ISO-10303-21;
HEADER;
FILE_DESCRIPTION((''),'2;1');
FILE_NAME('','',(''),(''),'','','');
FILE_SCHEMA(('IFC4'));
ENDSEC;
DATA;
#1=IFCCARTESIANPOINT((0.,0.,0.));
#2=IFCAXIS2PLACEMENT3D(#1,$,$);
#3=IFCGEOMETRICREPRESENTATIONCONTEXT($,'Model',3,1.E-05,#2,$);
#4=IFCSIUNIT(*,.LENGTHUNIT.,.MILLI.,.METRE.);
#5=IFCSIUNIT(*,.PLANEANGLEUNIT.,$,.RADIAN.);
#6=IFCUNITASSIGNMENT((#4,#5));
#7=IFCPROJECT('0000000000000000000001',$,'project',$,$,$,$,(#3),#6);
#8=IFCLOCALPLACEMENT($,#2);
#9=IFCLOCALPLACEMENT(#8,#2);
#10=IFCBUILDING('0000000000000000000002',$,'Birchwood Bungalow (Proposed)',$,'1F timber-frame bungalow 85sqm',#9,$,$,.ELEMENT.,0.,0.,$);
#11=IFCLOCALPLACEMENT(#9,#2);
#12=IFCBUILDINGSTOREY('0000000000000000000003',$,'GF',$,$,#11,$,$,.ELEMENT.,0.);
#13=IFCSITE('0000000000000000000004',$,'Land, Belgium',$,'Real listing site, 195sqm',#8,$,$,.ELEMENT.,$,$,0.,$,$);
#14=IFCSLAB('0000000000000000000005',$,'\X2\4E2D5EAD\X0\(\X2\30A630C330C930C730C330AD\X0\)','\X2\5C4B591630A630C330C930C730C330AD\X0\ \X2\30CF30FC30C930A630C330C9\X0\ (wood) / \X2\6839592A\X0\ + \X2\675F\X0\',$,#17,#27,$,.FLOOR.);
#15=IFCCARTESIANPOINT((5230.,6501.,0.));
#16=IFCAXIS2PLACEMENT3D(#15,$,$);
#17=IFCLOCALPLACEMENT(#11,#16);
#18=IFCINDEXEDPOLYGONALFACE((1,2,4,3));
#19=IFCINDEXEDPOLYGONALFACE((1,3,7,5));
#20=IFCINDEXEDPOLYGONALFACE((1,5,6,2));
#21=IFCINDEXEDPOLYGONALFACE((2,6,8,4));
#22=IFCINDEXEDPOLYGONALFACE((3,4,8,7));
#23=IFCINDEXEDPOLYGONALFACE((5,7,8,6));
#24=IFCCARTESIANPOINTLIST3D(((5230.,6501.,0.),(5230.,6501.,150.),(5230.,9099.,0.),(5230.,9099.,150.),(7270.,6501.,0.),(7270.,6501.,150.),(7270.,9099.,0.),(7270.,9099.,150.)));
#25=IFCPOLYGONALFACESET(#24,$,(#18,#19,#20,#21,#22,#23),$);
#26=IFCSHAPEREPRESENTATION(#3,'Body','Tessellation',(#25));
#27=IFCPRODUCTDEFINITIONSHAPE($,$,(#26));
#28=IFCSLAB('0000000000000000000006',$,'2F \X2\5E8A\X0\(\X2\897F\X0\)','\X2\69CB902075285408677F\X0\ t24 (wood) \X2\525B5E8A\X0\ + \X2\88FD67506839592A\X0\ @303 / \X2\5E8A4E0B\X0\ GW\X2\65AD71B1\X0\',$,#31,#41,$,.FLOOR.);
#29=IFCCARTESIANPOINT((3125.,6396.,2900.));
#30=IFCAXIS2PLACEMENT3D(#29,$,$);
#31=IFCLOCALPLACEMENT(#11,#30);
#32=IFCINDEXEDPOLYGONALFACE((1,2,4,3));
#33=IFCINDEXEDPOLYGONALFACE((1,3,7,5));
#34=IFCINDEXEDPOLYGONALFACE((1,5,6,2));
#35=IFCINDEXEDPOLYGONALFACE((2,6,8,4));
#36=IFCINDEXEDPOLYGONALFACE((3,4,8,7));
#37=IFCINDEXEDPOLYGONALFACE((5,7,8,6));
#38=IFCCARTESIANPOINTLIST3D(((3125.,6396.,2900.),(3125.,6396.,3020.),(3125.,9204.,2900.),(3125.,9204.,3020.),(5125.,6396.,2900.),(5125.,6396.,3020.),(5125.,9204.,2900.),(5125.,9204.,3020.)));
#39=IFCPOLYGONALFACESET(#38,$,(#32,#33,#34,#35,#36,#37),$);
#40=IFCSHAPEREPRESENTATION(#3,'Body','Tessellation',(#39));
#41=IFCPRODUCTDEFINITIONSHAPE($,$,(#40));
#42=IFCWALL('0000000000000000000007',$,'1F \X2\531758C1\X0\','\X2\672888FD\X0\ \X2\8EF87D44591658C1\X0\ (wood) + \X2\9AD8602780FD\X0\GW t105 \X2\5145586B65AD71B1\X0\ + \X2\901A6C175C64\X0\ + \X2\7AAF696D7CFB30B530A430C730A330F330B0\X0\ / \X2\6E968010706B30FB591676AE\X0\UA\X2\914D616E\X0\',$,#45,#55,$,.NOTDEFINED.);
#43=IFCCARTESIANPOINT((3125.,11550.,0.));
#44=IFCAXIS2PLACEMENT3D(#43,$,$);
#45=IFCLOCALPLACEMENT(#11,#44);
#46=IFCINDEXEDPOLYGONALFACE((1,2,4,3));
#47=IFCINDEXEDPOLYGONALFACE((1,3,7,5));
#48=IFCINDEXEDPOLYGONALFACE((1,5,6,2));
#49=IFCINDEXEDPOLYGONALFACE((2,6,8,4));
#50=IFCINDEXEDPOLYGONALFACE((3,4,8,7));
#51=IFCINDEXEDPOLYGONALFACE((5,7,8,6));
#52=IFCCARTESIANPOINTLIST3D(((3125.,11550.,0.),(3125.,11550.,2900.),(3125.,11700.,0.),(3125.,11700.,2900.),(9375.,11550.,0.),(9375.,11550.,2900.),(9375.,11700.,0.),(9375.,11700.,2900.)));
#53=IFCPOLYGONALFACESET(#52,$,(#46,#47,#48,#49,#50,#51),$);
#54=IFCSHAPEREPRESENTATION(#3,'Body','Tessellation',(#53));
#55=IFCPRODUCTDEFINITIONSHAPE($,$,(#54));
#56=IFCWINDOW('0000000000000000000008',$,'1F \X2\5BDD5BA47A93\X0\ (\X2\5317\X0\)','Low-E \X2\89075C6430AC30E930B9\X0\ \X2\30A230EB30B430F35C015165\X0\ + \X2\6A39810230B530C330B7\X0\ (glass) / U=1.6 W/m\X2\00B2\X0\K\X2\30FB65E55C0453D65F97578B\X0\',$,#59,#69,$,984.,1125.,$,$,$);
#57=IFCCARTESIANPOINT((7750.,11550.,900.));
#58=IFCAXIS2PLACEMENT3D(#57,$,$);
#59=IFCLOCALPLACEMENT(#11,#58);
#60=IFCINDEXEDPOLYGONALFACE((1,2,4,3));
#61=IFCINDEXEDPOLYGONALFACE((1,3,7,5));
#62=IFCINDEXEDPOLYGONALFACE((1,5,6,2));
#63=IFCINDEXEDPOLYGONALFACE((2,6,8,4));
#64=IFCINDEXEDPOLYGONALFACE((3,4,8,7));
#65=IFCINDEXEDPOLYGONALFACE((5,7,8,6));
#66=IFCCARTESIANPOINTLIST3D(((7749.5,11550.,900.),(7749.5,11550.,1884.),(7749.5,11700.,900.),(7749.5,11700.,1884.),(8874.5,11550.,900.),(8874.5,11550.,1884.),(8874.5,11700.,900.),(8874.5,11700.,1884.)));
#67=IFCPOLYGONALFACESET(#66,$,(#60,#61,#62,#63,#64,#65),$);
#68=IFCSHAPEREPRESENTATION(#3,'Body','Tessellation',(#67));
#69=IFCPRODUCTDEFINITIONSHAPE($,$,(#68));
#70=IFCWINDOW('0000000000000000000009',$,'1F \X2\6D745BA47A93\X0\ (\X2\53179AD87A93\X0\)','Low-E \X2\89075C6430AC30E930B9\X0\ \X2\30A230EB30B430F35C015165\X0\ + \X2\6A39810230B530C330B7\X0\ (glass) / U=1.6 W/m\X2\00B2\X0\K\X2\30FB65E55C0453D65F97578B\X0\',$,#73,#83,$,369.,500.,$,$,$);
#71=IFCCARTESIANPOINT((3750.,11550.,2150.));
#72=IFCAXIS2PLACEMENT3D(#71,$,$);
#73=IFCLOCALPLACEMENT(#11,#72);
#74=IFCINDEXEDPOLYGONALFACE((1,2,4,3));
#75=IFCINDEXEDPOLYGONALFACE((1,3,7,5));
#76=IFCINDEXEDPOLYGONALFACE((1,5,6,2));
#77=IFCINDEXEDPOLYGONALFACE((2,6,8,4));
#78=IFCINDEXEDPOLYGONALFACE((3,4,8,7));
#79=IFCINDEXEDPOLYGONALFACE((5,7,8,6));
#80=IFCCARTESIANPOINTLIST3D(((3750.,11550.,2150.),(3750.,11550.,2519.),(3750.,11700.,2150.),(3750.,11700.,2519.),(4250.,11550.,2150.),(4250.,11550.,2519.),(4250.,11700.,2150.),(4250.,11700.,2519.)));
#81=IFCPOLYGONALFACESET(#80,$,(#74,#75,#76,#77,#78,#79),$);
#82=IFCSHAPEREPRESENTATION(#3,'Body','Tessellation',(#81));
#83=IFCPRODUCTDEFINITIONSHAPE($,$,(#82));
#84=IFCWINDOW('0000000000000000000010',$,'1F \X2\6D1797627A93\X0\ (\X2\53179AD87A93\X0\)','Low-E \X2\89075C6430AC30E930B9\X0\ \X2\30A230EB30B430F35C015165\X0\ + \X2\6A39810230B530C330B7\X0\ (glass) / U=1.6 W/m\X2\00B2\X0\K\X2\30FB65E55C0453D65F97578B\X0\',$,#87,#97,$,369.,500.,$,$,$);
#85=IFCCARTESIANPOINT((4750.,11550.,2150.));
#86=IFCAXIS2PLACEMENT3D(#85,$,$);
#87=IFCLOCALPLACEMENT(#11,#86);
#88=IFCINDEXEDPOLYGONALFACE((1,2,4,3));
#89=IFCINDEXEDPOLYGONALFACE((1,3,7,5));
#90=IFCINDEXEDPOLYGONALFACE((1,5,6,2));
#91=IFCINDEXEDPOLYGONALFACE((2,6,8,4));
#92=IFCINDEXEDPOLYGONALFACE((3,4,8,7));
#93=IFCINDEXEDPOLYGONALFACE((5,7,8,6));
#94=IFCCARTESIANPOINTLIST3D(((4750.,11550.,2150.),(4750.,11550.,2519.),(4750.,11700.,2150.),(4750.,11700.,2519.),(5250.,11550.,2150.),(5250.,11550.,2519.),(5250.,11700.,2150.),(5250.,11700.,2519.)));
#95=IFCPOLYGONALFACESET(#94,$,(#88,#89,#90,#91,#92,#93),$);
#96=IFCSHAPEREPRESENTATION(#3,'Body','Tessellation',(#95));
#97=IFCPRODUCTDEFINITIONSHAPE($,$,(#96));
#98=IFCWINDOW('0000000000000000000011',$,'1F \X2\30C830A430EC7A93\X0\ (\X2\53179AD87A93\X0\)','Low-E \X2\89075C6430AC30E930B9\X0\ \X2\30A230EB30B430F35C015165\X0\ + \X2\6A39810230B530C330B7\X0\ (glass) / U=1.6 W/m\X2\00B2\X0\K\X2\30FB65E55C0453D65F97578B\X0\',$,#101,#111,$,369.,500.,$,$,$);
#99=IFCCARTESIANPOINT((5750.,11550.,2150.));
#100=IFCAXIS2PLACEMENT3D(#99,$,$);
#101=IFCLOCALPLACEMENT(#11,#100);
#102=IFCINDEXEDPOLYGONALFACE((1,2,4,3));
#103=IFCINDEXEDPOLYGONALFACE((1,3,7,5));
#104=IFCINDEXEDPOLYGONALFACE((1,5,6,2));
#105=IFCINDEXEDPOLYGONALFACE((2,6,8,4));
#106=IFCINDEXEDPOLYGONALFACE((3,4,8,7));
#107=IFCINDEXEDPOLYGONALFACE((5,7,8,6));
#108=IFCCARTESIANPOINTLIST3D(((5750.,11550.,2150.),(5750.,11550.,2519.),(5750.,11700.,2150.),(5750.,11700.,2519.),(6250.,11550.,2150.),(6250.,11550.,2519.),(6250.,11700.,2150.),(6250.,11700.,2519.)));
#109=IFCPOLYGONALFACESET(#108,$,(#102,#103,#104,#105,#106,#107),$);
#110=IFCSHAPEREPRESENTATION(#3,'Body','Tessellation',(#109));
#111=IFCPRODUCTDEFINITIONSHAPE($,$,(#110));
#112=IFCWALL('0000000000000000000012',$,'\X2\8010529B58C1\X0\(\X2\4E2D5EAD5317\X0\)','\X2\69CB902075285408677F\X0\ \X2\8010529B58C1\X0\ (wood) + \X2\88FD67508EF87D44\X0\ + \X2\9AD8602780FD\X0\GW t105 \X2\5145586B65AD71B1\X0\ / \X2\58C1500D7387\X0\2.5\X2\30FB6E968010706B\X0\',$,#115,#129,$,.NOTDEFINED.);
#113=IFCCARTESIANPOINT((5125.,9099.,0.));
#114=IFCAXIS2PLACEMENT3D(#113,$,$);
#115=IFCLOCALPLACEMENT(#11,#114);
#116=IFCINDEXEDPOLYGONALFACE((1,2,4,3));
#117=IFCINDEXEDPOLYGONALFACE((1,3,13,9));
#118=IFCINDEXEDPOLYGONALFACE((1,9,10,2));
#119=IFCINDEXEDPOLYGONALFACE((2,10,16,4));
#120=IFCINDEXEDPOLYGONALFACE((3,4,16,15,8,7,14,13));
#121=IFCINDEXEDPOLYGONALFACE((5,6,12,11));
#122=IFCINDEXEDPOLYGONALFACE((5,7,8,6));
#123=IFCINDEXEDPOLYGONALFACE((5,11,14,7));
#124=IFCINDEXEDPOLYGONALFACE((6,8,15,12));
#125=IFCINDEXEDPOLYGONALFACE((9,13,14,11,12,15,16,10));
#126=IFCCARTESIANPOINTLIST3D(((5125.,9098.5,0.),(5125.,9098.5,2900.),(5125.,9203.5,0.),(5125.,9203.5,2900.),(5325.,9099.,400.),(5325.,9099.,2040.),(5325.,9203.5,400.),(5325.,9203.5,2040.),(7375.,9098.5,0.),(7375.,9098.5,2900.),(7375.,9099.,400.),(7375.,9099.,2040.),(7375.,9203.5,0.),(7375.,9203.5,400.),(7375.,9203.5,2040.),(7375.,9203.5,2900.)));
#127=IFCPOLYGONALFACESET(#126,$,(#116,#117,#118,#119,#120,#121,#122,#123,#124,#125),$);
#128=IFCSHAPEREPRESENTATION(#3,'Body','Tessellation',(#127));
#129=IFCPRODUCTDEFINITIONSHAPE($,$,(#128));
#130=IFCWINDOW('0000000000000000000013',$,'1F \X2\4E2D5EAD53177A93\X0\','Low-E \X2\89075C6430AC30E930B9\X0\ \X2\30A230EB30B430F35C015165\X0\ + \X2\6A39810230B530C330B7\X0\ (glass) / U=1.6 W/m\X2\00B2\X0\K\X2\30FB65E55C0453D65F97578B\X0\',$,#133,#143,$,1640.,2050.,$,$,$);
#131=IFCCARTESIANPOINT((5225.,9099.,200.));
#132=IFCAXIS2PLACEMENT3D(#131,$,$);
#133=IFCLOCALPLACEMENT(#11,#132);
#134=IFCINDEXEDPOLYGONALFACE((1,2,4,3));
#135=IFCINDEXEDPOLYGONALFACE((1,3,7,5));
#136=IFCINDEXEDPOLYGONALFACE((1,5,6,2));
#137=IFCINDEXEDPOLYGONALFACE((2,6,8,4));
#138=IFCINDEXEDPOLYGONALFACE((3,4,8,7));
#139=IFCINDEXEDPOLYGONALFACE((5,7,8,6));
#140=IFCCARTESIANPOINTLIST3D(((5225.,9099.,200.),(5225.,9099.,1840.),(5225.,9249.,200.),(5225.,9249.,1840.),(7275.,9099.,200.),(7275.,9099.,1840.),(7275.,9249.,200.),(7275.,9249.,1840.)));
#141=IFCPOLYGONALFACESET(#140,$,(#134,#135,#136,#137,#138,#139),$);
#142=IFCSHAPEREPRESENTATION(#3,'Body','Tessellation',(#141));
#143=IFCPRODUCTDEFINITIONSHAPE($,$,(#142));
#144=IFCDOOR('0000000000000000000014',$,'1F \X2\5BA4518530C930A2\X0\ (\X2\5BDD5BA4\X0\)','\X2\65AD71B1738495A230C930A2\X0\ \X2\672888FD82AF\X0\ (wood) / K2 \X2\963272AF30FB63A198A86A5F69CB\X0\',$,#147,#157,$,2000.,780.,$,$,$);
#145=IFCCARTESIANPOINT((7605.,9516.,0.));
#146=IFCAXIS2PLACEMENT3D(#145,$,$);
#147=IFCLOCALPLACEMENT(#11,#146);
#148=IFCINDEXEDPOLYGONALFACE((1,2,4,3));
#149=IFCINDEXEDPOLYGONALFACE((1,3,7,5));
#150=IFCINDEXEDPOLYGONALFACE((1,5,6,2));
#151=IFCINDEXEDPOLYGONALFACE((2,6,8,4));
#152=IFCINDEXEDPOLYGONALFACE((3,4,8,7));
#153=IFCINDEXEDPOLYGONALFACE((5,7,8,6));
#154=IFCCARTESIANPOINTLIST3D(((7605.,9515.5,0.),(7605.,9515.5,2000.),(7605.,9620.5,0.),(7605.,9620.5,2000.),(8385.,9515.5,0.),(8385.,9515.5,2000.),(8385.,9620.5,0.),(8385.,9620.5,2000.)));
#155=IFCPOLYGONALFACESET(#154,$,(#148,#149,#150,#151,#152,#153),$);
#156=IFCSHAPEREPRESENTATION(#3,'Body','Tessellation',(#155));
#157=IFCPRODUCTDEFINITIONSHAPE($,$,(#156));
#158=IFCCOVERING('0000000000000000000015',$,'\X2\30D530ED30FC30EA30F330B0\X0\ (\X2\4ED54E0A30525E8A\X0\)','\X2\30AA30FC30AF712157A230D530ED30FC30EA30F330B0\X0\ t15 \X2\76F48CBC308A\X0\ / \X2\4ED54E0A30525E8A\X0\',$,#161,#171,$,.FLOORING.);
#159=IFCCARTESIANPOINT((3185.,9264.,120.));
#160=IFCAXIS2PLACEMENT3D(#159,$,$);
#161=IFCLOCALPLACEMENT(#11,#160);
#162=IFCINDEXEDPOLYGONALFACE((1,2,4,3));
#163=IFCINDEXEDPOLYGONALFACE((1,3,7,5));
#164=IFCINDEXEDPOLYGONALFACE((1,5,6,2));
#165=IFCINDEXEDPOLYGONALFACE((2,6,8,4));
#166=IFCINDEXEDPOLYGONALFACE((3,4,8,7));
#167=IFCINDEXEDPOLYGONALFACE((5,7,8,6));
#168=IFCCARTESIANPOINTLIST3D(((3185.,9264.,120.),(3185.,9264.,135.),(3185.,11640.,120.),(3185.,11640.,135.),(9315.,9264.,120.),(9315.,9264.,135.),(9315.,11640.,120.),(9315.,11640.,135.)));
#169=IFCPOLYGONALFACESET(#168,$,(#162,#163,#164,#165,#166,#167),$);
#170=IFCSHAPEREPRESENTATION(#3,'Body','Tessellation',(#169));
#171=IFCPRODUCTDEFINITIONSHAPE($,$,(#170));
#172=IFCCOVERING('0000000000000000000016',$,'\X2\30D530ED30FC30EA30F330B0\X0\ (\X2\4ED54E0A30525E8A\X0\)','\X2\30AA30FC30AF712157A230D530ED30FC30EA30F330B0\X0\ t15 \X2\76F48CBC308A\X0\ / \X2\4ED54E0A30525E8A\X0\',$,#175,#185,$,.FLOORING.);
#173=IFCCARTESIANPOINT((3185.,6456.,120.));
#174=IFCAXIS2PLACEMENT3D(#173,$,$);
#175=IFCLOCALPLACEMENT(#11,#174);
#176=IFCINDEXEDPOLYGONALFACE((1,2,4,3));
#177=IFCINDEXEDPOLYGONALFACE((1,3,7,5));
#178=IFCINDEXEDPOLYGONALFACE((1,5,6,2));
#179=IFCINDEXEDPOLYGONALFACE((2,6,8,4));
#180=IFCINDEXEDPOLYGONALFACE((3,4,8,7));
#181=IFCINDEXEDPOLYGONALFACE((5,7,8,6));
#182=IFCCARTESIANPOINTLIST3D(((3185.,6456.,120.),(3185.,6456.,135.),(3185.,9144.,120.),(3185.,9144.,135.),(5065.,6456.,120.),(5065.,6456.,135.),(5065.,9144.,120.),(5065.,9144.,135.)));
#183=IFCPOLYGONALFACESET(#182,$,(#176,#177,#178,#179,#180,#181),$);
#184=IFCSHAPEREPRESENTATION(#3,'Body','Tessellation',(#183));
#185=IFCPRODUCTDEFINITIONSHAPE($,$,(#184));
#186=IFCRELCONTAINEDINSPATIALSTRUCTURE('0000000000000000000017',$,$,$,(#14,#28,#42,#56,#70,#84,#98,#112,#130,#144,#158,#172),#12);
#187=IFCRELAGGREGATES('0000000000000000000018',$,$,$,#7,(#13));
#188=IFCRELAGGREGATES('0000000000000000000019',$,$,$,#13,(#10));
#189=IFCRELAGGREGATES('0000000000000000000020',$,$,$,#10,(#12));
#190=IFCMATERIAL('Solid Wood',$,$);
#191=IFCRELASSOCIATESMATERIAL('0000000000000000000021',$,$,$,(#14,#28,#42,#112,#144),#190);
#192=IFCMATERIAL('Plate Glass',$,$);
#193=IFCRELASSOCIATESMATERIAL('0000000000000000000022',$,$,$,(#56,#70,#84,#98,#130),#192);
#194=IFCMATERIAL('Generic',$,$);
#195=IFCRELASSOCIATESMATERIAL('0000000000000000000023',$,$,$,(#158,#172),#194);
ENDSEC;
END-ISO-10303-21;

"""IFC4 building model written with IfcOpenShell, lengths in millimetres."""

from ifc_helpers import new_model, si_unit, frame, frame_2d, origin, place, context, project, spatial, rectangle, extrude, material, element, fill, save


model = new_model("IFC4")

# Units and contexts
model_context = context("Model", 3, precision=1e-05, world=origin())
ifc_project = project(units=[si_unit("LENGTHUNIT", "METRE", prefix="MILLI"), si_unit("PLANEANGLEUNIT", "RADIAN")], contexts=[model_context])

# Site, building, storey
site_placement = place(None, origin())
site = spatial("IfcSite", under=ifc_project, at=site_placement, Name="Land, Belgium", ObjectType="Real listing site, 195sqm", CompositionType="ELEMENT", RefElevation=0.0)
building_placement = place(site_placement, origin())
building = spatial("IfcBuilding", under=site, at=building_placement, Name="Birchwood Bungalow (Proposed)", ObjectType="1F timber-frame bungalow 85sqm", CompositionType="ELEMENT", ElevationOfRefHeight=0.0, ElevationOfTerrain=0.0)
storey_placement = place(building_placement, origin())
storey = spatial("IfcBuildingStorey", under=building, at=storey_placement, Name="GF", CompositionType="ELEMENT", Elevation=0.0)

# Slabs
ifc_material_1 = material(Name="Solid Wood")
slab_1_placement = place(storey_placement, frame((5230.0, 6501.0, 0.0)))
element("IfcSlab", 1, at=slab_1_placement, inside=storey, material=ifc_material_1, Name="中庭(ウッドデッキ)", Description="屋外ウッドデッキ ハードウッド (wood) / 根太 + 束", PredefinedType="FLOOR", context=model_context, shape_type="SweptSolid", body=[
    extrude(rectangle(XDim=2040.0, YDim=2598.0, at=frame_2d((1020.0, 1299.0))), frame((5230.0, 6501.0, 0.0)), (0.0, 0.0, 1.0), 150.0),
])
slab_2_placement = place(storey_placement, frame((3125.0, 6396.0, 2900.0)))
element("IfcSlab", 2, at=slab_2_placement, inside=storey, material=ifc_material_1, Name="2F 床(西)", Description="構造用合板 t24 (wood) 剛床 + 製材根太 @303 / 床下 GW断熱", PredefinedType="FLOOR", context=model_context, shape_type="SweptSolid", body=[
    extrude(rectangle(XDim=2000.0, YDim=2808.0, at=frame_2d((1000.0, 1404.0))), frame((3125.0, 6396.0, 2900.0)), (0.0, 0.0, 1.0), 120.0),
])

# Wall, openings, windows
wall_1_placement = place(storey_placement, frame((3125.0, 11550.0, 0.0)))
wall_1 = element("IfcWall", 3, at=wall_1_placement, inside=storey, material=ifc_material_1, Name="1F 北壁", Description="木製 軸組外壁 (wood) + 高性能GW t105 充填断熱 + 通気層 + 窯業系サイディング / 準耐火・外皮UA配慮", PredefinedType="NOTDEFINED", context=model_context, shape_type="SweptSolid", body=[
    extrude(rectangle(XDim=6250.0, YDim=150.0, at=frame_2d((3125.0, 75.0))), frame((3125.0, 11550.0, 0.0)), (0.0, 0.0, 1.0), 2900.0),
])
opening_1_placement = place(storey_placement, frame((7750.0, 11550.0, 900.0)))
opening_1 = element("IfcOpeningElement", 4, at=opening_1_placement, cuts=wall_1, PredefinedType="NOTDEFINED", context=model_context, shape_type="SweptSolid", body=[
    extrude(rectangle(XDim=1125.0, YDim=150.0, at=frame_2d((562.0, 75.0))), frame((7750.0, 11550.0, 900.0)), (0.0, 0.0, 1.0), 984.0),
])
opening_2_placement = place(storey_placement, frame((3750.0, 11550.0, 2150.0)))
opening_2 = element("IfcOpeningElement", 5, at=opening_2_placement, cuts=wall_1, PredefinedType="NOTDEFINED", context=model_context, shape_type="SweptSolid", body=[
    extrude(rectangle(XDim=500.0, YDim=150.0, at=frame_2d((250.0, 75.0))), frame((3750.0, 11550.0, 2150.0)), (0.0, 0.0, 1.0), 369.0),
])
opening_3_placement = place(storey_placement, frame((4750.0, 11550.0, 2150.0)))
opening_3 = element("IfcOpeningElement", 6, at=opening_3_placement, cuts=wall_1, PredefinedType="NOTDEFINED", context=model_context, shape_type="SweptSolid", body=[
    extrude(rectangle(XDim=500.0, YDim=150.0, at=frame_2d((250.0, 75.0))), frame((4750.0, 11550.0, 2150.0)), (0.0, 0.0, 1.0), 369.0),
])
opening_4_placement = place(storey_placement, frame((5750.0, 11550.0, 2150.0)))
opening_4 = element("IfcOpeningElement", 7, at=opening_4_placement, cuts=wall_1, PredefinedType="NOTDEFINED", context=model_context, shape_type="SweptSolid", body=[
    extrude(rectangle(XDim=500.0, YDim=150.0, at=frame_2d((250.0, 75.0))), frame((5750.0, 11550.0, 2150.0)), (0.0, 0.0, 1.0), 369.0),
])
ifc_material_2 = material(Name="Plate Glass")
window_1_placement = place(storey_placement, frame((7750.0, 11550.0, 900.0)))
window_1 = element("IfcWindow", 8, at=window_1_placement, inside=storey, material=ifc_material_2, Name="1F 寝室窓 (北)", Description="Low-E 複層ガラス アルゴン封入 + 樹脂サッシ (glass) / U=1.6 W/m²K・日射取得型", OverallHeight=984.0, OverallWidth=1125.0, context=model_context, shape_type="SweptSolid", body=[
    extrude(rectangle(XDim=1125.0, YDim=150.0, at=frame_2d((562.0, 75.0))), frame((7750.0, 11550.0, 900.0)), (0.0, 0.0, 1.0), 984.0),
])
fill(opening_1, window_1)
window_2_placement = place(storey_placement, frame((3750.0, 11550.0, 2150.0)))
window_2 = element("IfcWindow", 9, at=window_2_placement, inside=storey, material=ifc_material_2, Name="1F 浴室窓 (北高窓)", Description="Low-E 複層ガラス アルゴン封入 + 樹脂サッシ (glass) / U=1.6 W/m²K・日射取得型", OverallHeight=369.0, OverallWidth=500.0, context=model_context, shape_type="SweptSolid", body=[
    extrude(rectangle(XDim=500.0, YDim=150.0, at=frame_2d((250.0, 75.0))), frame((3750.0, 11550.0, 2150.0)), (0.0, 0.0, 1.0), 369.0),
])
fill(opening_2, window_2)
window_3_placement = place(storey_placement, frame((4750.0, 11550.0, 2150.0)))
window_3 = element("IfcWindow", 10, at=window_3_placement, inside=storey, material=ifc_material_2, Name="1F 洗面窓 (北高窓)", Description="Low-E 複層ガラス アルゴン封入 + 樹脂サッシ (glass) / U=1.6 W/m²K・日射取得型", OverallHeight=369.0, OverallWidth=500.0, context=model_context, shape_type="SweptSolid", body=[
    extrude(rectangle(XDim=500.0, YDim=150.0, at=frame_2d((250.0, 75.0))), frame((4750.0, 11550.0, 2150.0)), (0.0, 0.0, 1.0), 369.0),
])
fill(opening_3, window_3)
window_4_placement = place(storey_placement, frame((5750.0, 11550.0, 2150.0)))
window_4 = element("IfcWindow", 11, at=window_4_placement, inside=storey, material=ifc_material_2, Name="1F トイレ窓 (北高窓)", Description="Low-E 複層ガラス アルゴン封入 + 樹脂サッシ (glass) / U=1.6 W/m²K・日射取得型", OverallHeight=369.0, OverallWidth=500.0, context=model_context, shape_type="SweptSolid", body=[
    extrude(rectangle(XDim=500.0, YDim=150.0, at=frame_2d((250.0, 75.0))), frame((5750.0, 11550.0, 2150.0)), (0.0, 0.0, 1.0), 369.0),
])
fill(opening_4, window_4)

# Wall, opening, window
wall_2_placement = place(storey_placement, frame((5125.0, 9099.0, 0.0)))
wall_2 = element("IfcWall", 12, at=wall_2_placement, inside=storey, material=ifc_material_1, Name="耐力壁(中庭北)", Description="構造用合板 耐力壁 (wood) + 製材軸組 + 高性能GW t105 充填断熱 / 壁倍率2.5・準耐火", PredefinedType="NOTDEFINED", context=model_context, shape_type="SweptSolid", body=[
    extrude(rectangle(XDim=2250.0, YDim=105.0, at=frame_2d((1125.0, 52.0))), frame((5125.0, 9099.0, 0.0)), (0.0, 0.0, 1.0), 2900.0),
])
opening_5_placement = place(storey_placement, frame((5225.0, 9099.0, 200.0)))
opening_5 = element("IfcOpeningElement", 13, at=opening_5_placement, cuts=wall_2, PredefinedType="NOTDEFINED", context=model_context, shape_type="SweptSolid", body=[
    extrude(rectangle(XDim=2050.0, YDim=150.0, at=frame_2d((1025.0, 75.0))), frame((5225.0, 9099.0, 200.0)), (0.0, 0.0, 1.0), 1640.0),
])
window_5_placement = place(storey_placement, frame((5225.0, 9099.0, 200.0)))
window_5 = element("IfcWindow", 14, at=window_5_placement, inside=storey, material=ifc_material_2, Name="1F 中庭北窓", Description="Low-E 複層ガラス アルゴン封入 + 樹脂サッシ (glass) / U=1.6 W/m²K・日射取得型", OverallHeight=1640.0, OverallWidth=2050.0, context=model_context, shape_type="SweptSolid", body=[
    extrude(rectangle(XDim=2050.0, YDim=150.0, at=frame_2d((1025.0, 75.0))), frame((5225.0, 9099.0, 200.0)), (0.0, 0.0, 1.0), 1640.0),
])
fill(opening_5, window_5)

# Door
door_1_placement = place(storey_placement, frame((7605.0, 9516.0, 0.0)))
element("IfcDoor", 15, at=door_1_placement, inside=storey, material=ifc_material_1, Name="1F 室内ドア (寝室)", Description="断熱玄関ドア 木製芯 (wood) / K2 防犯・採風機構", OverallHeight=2000.0, OverallWidth=780.0, context=model_context, shape_type="SweptSolid", body=[
    extrude(rectangle(XDim=780.0, YDim=105.0, at=frame_2d((390.0, 52.0))), frame((7605.0, 9516.0, 0.0)), (0.0, 0.0, 1.0), 2000.0),
])

# Coverings
ifc_material_3 = material(Name="Generic")
covering_1_placement = place(storey_placement, frame((3185.0, 9264.0, 120.0)))
element("IfcCovering", 16, at=covering_1_placement, inside=storey, material=ifc_material_3, Name="フローリング (仕上げ床)", Description="オーク無垢フローリング t15 直貼り / 仕上げ床", PredefinedType="FLOORING", context=model_context, shape_type="SweptSolid", body=[
    extrude(rectangle(XDim=6130.0, YDim=2376.0, at=frame_2d((3065.0, 1188.0))), frame((3185.0, 9264.0, 120.0)), (0.0, 0.0, 1.0), 15.0),
])
covering_2_placement = place(storey_placement, frame((3185.0, 6456.0, 120.0)))
element("IfcCovering", 17, at=covering_2_placement, inside=storey, material=ifc_material_3, Name="フローリング (仕上げ床)", Description="オーク無垢フローリング t15 直貼り / 仕上げ床", PredefinedType="FLOORING", context=model_context, shape_type="SweptSolid", body=[
    extrude(rectangle(XDim=1880.0, YDim=2688.0, at=frame_2d((940.0, 1344.0))), frame((3185.0, 6456.0, 120.0)), (0.0, 0.0, 1.0), 15.0),
])

save(model, "model.ifc")
